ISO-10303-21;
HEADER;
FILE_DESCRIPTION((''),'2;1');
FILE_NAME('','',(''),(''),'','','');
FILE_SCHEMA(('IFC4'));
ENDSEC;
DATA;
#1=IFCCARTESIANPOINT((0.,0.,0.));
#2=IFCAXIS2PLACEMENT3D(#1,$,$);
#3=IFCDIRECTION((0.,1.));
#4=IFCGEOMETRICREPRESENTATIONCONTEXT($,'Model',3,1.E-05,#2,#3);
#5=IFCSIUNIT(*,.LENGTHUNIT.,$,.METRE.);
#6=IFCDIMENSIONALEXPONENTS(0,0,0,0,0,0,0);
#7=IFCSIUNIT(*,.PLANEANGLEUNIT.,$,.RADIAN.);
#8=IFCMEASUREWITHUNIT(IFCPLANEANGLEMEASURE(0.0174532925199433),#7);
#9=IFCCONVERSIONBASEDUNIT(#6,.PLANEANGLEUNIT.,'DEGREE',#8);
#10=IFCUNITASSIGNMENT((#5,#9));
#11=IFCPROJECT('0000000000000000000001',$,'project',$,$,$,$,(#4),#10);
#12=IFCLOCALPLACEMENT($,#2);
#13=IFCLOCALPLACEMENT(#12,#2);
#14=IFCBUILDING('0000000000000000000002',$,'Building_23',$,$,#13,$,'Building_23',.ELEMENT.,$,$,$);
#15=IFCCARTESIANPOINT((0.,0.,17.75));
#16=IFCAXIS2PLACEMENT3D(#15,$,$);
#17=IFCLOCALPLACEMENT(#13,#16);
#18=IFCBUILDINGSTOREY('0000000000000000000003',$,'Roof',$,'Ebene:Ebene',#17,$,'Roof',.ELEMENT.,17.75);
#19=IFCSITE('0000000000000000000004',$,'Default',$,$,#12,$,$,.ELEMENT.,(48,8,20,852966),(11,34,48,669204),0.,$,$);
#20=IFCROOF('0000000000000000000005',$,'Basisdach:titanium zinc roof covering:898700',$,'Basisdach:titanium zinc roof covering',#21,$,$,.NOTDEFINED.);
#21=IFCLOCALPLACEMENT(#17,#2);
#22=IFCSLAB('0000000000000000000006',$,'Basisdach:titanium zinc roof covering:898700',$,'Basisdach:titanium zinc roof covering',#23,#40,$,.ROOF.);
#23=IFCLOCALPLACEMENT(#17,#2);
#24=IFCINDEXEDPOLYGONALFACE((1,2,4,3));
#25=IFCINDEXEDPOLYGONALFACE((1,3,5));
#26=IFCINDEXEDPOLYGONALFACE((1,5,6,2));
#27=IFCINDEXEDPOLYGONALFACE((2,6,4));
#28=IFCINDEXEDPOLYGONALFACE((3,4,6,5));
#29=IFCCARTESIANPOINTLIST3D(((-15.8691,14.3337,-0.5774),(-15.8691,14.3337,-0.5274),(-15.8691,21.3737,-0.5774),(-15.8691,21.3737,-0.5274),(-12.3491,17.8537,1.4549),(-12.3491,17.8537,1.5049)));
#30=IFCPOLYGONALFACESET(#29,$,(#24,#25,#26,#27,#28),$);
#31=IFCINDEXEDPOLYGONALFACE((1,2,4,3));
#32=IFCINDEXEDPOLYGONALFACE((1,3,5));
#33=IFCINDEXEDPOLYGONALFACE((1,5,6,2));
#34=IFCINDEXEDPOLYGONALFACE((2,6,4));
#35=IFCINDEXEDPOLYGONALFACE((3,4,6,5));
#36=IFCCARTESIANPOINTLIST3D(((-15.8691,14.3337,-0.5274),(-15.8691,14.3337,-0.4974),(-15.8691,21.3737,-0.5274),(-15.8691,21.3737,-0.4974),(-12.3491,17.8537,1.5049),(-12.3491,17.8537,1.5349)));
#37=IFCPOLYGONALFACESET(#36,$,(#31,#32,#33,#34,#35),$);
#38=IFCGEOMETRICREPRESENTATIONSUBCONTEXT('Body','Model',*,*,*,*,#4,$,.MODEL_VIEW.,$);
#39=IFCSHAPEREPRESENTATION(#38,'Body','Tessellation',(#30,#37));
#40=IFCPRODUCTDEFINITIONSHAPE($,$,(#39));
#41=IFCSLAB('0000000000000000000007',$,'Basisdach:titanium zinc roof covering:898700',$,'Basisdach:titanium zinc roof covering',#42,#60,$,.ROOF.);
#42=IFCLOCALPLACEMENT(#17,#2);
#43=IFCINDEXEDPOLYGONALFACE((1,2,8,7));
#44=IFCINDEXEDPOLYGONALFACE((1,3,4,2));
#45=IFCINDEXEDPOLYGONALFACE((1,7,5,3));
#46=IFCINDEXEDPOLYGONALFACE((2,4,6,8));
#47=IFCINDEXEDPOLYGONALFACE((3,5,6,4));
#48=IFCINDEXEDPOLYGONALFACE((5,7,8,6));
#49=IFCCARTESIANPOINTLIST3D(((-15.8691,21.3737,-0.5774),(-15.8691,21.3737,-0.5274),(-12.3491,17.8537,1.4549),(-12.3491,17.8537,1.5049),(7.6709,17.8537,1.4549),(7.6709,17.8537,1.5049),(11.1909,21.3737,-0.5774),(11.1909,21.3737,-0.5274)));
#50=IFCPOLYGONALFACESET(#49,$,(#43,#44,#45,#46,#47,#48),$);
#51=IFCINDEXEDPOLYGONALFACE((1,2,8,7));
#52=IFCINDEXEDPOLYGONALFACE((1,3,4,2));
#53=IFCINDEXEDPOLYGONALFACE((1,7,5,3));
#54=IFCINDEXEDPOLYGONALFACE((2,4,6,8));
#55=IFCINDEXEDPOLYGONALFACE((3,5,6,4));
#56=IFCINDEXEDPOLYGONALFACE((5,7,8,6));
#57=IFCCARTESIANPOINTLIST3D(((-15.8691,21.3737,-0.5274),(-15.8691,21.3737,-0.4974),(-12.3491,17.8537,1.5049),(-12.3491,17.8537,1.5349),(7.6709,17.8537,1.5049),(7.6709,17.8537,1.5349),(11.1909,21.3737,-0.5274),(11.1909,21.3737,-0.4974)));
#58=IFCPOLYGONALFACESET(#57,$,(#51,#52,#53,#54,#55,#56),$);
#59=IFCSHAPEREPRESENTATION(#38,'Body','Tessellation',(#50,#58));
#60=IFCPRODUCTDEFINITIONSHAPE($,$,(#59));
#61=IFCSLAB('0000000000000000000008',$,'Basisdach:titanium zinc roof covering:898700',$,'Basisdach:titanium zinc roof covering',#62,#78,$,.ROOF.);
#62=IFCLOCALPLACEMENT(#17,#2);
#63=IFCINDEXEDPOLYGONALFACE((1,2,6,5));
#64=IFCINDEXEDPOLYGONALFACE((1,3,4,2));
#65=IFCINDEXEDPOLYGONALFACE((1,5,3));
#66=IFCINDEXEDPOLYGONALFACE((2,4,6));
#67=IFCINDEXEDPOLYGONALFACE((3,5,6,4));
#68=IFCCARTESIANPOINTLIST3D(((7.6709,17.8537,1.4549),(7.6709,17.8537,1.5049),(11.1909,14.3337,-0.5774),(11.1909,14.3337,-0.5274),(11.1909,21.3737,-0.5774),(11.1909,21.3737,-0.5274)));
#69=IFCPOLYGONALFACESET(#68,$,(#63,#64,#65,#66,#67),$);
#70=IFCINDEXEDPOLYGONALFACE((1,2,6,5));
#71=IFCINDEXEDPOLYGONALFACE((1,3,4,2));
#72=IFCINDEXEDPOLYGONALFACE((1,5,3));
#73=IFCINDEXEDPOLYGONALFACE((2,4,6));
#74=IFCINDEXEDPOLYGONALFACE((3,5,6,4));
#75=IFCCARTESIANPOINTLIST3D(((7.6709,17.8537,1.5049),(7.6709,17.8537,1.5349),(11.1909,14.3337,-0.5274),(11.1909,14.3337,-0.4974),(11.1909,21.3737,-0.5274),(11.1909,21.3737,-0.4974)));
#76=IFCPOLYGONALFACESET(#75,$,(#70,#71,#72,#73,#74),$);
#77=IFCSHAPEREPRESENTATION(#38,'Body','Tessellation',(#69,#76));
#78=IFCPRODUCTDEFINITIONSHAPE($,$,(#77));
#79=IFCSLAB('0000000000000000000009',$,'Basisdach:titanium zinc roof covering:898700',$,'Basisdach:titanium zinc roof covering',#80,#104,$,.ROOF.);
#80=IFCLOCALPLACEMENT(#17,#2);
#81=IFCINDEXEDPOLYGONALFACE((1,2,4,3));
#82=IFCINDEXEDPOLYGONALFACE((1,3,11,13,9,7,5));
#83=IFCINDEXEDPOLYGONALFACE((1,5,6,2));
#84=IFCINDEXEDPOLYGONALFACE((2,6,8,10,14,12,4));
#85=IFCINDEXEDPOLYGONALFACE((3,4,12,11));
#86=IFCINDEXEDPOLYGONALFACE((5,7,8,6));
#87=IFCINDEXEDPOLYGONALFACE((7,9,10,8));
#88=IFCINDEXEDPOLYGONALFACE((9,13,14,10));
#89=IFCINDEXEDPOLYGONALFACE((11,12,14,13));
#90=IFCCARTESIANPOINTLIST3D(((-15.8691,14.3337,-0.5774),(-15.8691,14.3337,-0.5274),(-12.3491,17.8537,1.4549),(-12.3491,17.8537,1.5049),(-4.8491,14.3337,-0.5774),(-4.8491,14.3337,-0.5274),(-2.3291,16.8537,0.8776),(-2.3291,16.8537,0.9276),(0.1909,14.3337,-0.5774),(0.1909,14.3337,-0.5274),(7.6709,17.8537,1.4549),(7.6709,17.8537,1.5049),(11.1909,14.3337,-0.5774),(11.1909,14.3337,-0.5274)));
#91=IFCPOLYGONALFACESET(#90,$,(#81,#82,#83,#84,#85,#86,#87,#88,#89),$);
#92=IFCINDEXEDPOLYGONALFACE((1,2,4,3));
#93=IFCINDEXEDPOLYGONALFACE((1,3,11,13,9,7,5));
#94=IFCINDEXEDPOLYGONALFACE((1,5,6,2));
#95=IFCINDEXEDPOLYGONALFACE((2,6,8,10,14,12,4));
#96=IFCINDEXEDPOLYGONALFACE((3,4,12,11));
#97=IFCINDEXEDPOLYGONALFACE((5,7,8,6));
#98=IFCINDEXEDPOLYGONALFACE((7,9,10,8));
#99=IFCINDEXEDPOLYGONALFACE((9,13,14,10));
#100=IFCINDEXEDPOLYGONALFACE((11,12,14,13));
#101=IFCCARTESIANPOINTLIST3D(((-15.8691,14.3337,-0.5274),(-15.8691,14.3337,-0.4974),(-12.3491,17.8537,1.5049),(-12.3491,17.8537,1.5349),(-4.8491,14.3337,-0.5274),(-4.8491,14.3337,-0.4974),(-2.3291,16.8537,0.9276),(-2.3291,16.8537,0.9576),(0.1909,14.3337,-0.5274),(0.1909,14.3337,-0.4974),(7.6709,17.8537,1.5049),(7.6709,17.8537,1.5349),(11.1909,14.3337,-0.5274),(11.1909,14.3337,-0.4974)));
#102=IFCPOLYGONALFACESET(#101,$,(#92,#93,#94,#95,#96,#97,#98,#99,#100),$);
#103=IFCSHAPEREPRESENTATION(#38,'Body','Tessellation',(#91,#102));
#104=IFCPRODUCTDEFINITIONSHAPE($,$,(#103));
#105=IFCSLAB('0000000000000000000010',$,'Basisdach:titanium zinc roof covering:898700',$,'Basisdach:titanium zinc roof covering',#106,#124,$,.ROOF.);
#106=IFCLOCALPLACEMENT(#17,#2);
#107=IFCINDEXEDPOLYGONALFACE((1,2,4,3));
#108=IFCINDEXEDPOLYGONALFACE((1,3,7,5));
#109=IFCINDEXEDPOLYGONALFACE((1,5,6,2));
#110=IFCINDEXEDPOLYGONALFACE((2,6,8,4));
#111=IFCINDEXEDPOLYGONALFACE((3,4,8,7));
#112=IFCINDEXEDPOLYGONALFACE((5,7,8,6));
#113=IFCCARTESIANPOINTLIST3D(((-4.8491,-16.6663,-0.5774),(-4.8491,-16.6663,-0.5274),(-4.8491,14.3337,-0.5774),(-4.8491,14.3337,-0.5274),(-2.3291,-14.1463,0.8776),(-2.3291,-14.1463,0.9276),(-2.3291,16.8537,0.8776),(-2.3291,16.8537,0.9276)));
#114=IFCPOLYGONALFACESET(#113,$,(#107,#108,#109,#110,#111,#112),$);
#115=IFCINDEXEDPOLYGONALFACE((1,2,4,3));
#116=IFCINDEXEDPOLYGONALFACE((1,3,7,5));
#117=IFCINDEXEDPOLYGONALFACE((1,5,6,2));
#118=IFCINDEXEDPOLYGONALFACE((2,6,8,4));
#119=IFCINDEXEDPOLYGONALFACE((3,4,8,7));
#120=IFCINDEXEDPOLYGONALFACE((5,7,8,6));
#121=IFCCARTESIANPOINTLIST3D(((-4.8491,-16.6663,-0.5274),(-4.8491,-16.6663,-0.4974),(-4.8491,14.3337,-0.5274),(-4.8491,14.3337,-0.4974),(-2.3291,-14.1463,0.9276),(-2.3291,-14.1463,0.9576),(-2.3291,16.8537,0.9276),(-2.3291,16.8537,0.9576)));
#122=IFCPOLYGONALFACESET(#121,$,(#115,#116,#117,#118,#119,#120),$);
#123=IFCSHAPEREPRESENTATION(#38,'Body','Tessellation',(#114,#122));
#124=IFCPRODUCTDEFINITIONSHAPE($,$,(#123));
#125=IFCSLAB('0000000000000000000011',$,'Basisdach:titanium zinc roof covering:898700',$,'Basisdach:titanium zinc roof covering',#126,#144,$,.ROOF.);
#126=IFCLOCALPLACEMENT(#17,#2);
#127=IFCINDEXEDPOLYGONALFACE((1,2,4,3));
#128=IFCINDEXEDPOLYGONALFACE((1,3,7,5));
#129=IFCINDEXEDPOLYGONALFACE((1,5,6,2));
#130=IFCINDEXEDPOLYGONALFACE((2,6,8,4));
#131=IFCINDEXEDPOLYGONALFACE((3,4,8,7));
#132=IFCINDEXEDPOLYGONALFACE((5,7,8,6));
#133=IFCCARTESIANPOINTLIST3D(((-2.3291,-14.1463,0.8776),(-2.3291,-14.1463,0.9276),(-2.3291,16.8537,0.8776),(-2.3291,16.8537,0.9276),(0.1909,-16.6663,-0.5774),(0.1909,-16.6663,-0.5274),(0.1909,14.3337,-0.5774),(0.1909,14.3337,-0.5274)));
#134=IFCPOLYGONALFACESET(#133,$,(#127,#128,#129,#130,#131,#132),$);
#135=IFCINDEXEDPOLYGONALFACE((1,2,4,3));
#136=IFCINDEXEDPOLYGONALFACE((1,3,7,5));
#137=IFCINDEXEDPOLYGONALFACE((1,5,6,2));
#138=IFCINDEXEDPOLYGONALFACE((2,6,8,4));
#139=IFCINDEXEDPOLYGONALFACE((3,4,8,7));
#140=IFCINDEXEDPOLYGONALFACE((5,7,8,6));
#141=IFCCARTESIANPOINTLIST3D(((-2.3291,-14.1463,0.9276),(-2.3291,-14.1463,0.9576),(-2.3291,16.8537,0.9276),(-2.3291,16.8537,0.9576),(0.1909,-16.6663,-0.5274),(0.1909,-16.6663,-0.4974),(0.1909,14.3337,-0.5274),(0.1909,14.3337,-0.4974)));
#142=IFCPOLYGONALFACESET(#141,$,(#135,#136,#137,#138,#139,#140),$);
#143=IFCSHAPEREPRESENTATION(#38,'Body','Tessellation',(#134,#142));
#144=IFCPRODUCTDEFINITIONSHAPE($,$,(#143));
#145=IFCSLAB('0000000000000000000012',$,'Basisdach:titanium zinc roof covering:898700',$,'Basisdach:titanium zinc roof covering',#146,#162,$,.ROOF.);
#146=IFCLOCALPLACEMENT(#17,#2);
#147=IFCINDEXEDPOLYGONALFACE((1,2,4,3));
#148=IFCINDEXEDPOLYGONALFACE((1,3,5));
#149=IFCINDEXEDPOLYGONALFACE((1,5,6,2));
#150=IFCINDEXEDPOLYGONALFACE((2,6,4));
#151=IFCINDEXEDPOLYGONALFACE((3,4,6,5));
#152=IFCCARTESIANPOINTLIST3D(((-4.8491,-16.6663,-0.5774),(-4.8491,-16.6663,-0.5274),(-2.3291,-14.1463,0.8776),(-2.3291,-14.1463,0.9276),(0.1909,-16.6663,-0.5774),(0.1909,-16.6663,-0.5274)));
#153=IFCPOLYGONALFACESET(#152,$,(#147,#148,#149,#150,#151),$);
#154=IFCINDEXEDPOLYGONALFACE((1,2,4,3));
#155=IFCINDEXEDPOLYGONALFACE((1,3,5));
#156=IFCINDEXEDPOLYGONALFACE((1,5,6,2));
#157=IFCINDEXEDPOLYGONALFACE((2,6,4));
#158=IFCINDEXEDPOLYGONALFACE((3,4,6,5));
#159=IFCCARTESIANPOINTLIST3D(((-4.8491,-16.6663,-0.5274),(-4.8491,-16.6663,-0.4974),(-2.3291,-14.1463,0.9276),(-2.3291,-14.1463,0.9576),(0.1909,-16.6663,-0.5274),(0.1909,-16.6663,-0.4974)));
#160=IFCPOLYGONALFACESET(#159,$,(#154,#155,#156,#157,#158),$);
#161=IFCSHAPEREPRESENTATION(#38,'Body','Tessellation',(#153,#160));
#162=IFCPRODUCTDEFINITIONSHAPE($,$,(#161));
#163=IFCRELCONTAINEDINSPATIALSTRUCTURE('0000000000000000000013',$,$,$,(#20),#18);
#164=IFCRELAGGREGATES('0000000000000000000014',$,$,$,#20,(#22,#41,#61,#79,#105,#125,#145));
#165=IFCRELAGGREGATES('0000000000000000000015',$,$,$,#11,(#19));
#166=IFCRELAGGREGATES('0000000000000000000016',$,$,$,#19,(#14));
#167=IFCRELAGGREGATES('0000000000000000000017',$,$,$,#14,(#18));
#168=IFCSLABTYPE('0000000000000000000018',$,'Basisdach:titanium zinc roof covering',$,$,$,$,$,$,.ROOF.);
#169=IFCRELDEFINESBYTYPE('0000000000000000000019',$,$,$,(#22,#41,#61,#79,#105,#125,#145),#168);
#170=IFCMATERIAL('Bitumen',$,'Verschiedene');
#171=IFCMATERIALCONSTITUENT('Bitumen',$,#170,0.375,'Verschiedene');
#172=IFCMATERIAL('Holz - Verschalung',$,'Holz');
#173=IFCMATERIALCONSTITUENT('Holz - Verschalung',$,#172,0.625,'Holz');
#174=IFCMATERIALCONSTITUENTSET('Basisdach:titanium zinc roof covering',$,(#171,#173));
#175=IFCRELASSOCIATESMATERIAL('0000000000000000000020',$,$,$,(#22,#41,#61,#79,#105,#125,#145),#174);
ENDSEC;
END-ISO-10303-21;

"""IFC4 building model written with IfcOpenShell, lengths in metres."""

from ifc_helpers import new_model, entity, si_unit, converted_unit, direction, frame, origin, place, context, subcontext, project, spatial, indexed_curve, outline, extrude, material, constituent, constituent_set, type_object, element, aggregate, save


model = new_model("IFC4")

# Units and contexts
model_context = context("Model", 3, precision=1e-05, world=origin(), true_north=direction((0.0, 1.0)))
body_context = subcontext(model_context, "Body", "Model", "MODEL_VIEW")
ifc_project = project(units=[si_unit("LENGTHUNIT", "METRE"), converted_unit("PLANEANGLEUNIT", "DEGREE", entity("IfcPlaneAngleMeasure", 0.0174532925199433), si_unit("PLANEANGLEUNIT", "RADIAN"), dimensions=[0, 0, 0, 0, 0, 0, 0])], contexts=[model_context])

# Site, building, storey
site_placement = place(None, origin())
site = spatial("IfcSite", under=ifc_project, at=site_placement, Name="Default", CompositionType="ELEMENT", RefLatitude=(48, 8, 20, 852966), RefLongitude=(11, 34, 48, 669204), RefElevation=0.0)
building_placement = place(site_placement, origin())
building = spatial("IfcBuilding", under=site, at=building_placement, Name="Building_23", LongName="Building_23", CompositionType="ELEMENT")
storey_placement = place(building_placement, frame((0.0, 0.0, 17.75)))
storey = spatial("IfcBuildingStorey", under=building, at=storey_placement, Name="Roof", ObjectType="Ebene:Ebene", LongName="Roof", CompositionType="ELEMENT", Elevation=17.75)

# Roof, slabs
roof_placement = place(storey_placement, frame((-15.8691, -16.6663, -0.5774)))
roof = element("IfcRoof", 1, at=roof_placement, inside=storey, Name="Basisdach:titanium zinc roof covering:898700", ObjectType="Basisdach:titanium zinc roof covering", PredefinedType="NOTDEFINED")
ifc_material_1 = material(Name="Bitumen", Category="Verschiedene")
ifc_constituent_1 = constituent(ifc_material_1, Name="Bitumen", Category="Verschiedene", fraction=0.375)
ifc_material_2 = material(Name="Holz - Verschalung", Category="Holz")
ifc_constituent_2 = constituent(ifc_material_2, Name="Holz - Verschalung", Category="Holz", fraction=0.625)
ifc_constituent_set = constituent_set(constituents=[ifc_constituent_1, ifc_constituent_2], Name="Basisdach:titanium zinc roof covering")
slab_type = type_object("IfcSlabType", Name="Basisdach:titanium zinc roof covering", PredefinedType="ROOF")
slab_1_placement = place(roof_placement, origin())
slab_1 = element("IfcSlab", 2, at=slab_1_placement, type_object=slab_type, material=ifc_constituent_set, Name="Basisdach:titanium zinc roof covering:898700", ObjectType="Basisdach:titanium zinc roof covering", PredefinedType="ROOF", context=body_context, shape_type="SweptSolid", body=[
    extrude(outline(indexed_curve([(2.0323, 0.0), (-2.0323, 3.52), (-2.0323, -3.52), (2.0323, 0.0)], self_intersect=False)), frame((1.76, 34.52, 1.0161), z_axis=(-0.5, 0.0, 0.866025), x_axis=(0.866025, 0.0, 0.5)), (0.5, 0.0, 0.866025), 0.05),
    extrude(outline(indexed_curve([(2.0323, 0.0), (-2.0323, 3.52), (-2.0323, -3.52), (2.0323, 0.0)], self_intersect=False)), frame((1.76, 34.52, 1.0661), z_axis=(-0.5, 0.0, 0.866025), x_axis=(0.866025, 0.0, 0.5)), (0.5, 0.0, 0.866025), 0.03),
])
slab_2_placement = place(roof_placement, origin())
slab_2 = element("IfcSlab", 3, at=slab_2_placement, type_object=slab_type, material=ifc_constituent_set, Name="Basisdach:titanium zinc roof covering:898700", ObjectType="Basisdach:titanium zinc roof covering", PredefinedType="ROOF", context=body_context, shape_type="SweptSolid", body=[
    extrude(outline(indexed_curve([(13.53, 2.0323), (-13.53, 2.0323), (-10.01, -2.0323), (10.01, -2.0323), (13.53, 2.0323)], self_intersect=False)), frame((13.53, 36.28, 1.0161), z_axis=(0.0, 0.5, 0.866025), x_axis=(1.0, 0.0, 0.0)), (0.0, -0.5, 0.866025), 0.05),
    extrude(outline(indexed_curve([(13.53, 2.0323), (-13.53, 2.0323), (-10.01, -2.0323), (10.01, -2.0323), (13.53, 2.0323)], self_intersect=False)), frame((13.53, 36.28, 1.0661), z_axis=(0.0, 0.5, 0.866025), x_axis=(1.0, 0.0, 0.0)), (0.0, -0.5, 0.866025), 0.03),
])
slab_3_placement = place(roof_placement, origin())
slab_3 = element("IfcSlab", 4, at=slab_3_placement, type_object=slab_type, material=ifc_constituent_set, Name="Basisdach:titanium zinc roof covering:898700", ObjectType="Basisdach:titanium zinc roof covering", PredefinedType="ROOF", context=body_context, shape_type="SweptSolid", body=[
    extrude(outline(indexed_curve([(2.0323, -3.52), (2.0323, 3.52), (-2.0323, 0.0), (2.0323, -3.52)], self_intersect=False)), frame((25.3, 34.52, 1.0161), z_axis=(0.5, 0.0, 0.866025), x_axis=(0.866025, 0.0, -0.5)), (-0.5, 0.0, 0.866025), 0.05),
    extrude(outline(indexed_curve([(2.0323, -3.52), (2.0323, 3.52), (-2.0323, 0.0), (2.0323, -3.52)], self_intersect=False)), frame((25.3, 34.52, 1.0661), z_axis=(0.5, 0.0, 0.866025), x_axis=(0.866025, 0.0, -0.5)), (-0.5, 0.0, 0.866025), 0.03),
])
slab_4_placement = place(roof_placement, origin())
slab_4 = element("IfcSlab", 5, at=slab_4_placement, type_object=slab_type, material=ifc_constituent_set, Name="Basisdach:titanium zinc roof covering:898700", ObjectType="Basisdach:titanium zinc roof covering", PredefinedType="ROOF", context=body_context, shape_type="SweptSolid", body=[
    extrude(outline(indexed_curve([(-13.53, -2.0323), (-2.51, -2.0323), (0.01, 0.8776), (2.53, -2.0323), (13.53, -2.0323), (10.01, 2.0323), (-10.01, 2.0323), (-13.53, -2.0323)], self_intersect=False)), frame((13.53, 32.76, 1.0161), z_axis=(0.0, -0.5, 0.866025), x_axis=(1.0, 0.0, 0.0)), (0.0, 0.5, 0.866025), 0.05),
    extrude(outline(indexed_curve([(-13.53, -2.0323), (-2.51, -2.0323), (0.01, 0.8776), (2.53, -2.0323), (13.53, -2.0323), (10.01, 2.0323), (-10.01, 2.0323), (-13.53, -2.0323)], self_intersect=False)), frame((13.53, 32.76, 1.0661), z_axis=(0.0, -0.5, 0.866025), x_axis=(1.0, 0.0, 0.0)), (0.0, 0.5, 0.866025), 0.03),
])
slab_5_placement = place(roof_placement, origin())
slab_5 = element("IfcSlab", 6, at=slab_5_placement, type_object=slab_type, material=ifc_constituent_set, Name="Basisdach:titanium zinc roof covering:898700", ObjectType="Basisdach:titanium zinc roof covering", PredefinedType="ROOF", context=body_context, shape_type="SweptSolid", body=[
    extrude(outline(indexed_curve([(-1.4549, 14.24), (-1.4549, -16.76), (1.4549, -14.24), (1.4549, 16.76), (-1.4549, 14.24)], self_intersect=False)), frame((12.28, 16.76, 0.7275), z_axis=(-0.5, 0.0, 0.866025), x_axis=(0.866025, 0.0, 0.5)), (0.5, 0.0, 0.866025), 0.05),
    extrude(outline(indexed_curve([(-1.4549, 14.24), (-1.4549, -16.76), (1.4549, -14.24), (1.4549, 16.76), (-1.4549, 14.24)], self_intersect=False)), frame((12.28, 16.76, 0.7775), z_axis=(-0.5, 0.0, 0.866025), x_axis=(0.866025, 0.0, 0.5)), (0.5, 0.0, 0.866025), 0.03),
])
slab_6_placement = place(roof_placement, origin())
slab_6 = element("IfcSlab", 7, at=slab_6_placement, type_object=slab_type, material=ifc_constituent_set, Name="Basisdach:titanium zinc roof covering:898700", ObjectType="Basisdach:titanium zinc roof covering", PredefinedType="ROOF", context=body_context, shape_type="SweptSolid", body=[
    extrude(outline(indexed_curve([(1.4549, -16.76), (1.4549, 14.24), (-1.4549, 16.76), (-1.4549, -14.24), (1.4549, -16.76)], self_intersect=False)), frame((14.8, 16.76, 0.7275), z_axis=(0.5, 0.0, 0.866025), x_axis=(0.866025, 0.0, -0.5)), (-0.5, 0.0, 0.866025), 0.05),
    extrude(outline(indexed_curve([(1.4549, -16.76), (1.4549, 14.24), (-1.4549, 16.76), (-1.4549, -14.24), (1.4549, -16.76)], self_intersect=False)), frame((14.8, 16.76, 0.7775), z_axis=(0.5, 0.0, 0.866025), x_axis=(0.866025, 0.0, -0.5)), (-0.5, 0.0, 0.866025), 0.03),
])
slab_7_placement = place(roof_placement, origin())
slab_7 = element("IfcSlab", 8, at=slab_7_placement, type_object=slab_type, material=ifc_constituent_set, Name="Basisdach:titanium zinc roof covering:898700", ObjectType="Basisdach:titanium zinc roof covering", PredefinedType="ROOF", context=body_context, shape_type="SweptSolid", body=[
    extrude(outline(indexed_curve([(-2.52, -1.4549), (2.52, -1.4549), (0.0, 1.4549), (-2.52, -1.4549)], self_intersect=False)), frame((13.54, 1.26, 0.7275), z_axis=(0.0, -0.5, 0.866025), x_axis=(1.0, 0.0, 0.0)), (0.0, 0.5, 0.866025), 0.05),
    extrude(outline(indexed_curve([(-2.52, -1.4549), (2.52, -1.4549), (0.0, 1.4549), (-2.52, -1.4549)], self_intersect=False)), frame((13.54, 1.26, 0.7775), z_axis=(0.0, -0.5, 0.866025), x_axis=(1.0, 0.0, 0.0)), (0.0, 0.5, 0.866025), 0.03),
])
aggregate(roof, [slab_1, slab_2, slab_3, slab_4, slab_5, slab_6, slab_7])

save(model, "model.ifc")
